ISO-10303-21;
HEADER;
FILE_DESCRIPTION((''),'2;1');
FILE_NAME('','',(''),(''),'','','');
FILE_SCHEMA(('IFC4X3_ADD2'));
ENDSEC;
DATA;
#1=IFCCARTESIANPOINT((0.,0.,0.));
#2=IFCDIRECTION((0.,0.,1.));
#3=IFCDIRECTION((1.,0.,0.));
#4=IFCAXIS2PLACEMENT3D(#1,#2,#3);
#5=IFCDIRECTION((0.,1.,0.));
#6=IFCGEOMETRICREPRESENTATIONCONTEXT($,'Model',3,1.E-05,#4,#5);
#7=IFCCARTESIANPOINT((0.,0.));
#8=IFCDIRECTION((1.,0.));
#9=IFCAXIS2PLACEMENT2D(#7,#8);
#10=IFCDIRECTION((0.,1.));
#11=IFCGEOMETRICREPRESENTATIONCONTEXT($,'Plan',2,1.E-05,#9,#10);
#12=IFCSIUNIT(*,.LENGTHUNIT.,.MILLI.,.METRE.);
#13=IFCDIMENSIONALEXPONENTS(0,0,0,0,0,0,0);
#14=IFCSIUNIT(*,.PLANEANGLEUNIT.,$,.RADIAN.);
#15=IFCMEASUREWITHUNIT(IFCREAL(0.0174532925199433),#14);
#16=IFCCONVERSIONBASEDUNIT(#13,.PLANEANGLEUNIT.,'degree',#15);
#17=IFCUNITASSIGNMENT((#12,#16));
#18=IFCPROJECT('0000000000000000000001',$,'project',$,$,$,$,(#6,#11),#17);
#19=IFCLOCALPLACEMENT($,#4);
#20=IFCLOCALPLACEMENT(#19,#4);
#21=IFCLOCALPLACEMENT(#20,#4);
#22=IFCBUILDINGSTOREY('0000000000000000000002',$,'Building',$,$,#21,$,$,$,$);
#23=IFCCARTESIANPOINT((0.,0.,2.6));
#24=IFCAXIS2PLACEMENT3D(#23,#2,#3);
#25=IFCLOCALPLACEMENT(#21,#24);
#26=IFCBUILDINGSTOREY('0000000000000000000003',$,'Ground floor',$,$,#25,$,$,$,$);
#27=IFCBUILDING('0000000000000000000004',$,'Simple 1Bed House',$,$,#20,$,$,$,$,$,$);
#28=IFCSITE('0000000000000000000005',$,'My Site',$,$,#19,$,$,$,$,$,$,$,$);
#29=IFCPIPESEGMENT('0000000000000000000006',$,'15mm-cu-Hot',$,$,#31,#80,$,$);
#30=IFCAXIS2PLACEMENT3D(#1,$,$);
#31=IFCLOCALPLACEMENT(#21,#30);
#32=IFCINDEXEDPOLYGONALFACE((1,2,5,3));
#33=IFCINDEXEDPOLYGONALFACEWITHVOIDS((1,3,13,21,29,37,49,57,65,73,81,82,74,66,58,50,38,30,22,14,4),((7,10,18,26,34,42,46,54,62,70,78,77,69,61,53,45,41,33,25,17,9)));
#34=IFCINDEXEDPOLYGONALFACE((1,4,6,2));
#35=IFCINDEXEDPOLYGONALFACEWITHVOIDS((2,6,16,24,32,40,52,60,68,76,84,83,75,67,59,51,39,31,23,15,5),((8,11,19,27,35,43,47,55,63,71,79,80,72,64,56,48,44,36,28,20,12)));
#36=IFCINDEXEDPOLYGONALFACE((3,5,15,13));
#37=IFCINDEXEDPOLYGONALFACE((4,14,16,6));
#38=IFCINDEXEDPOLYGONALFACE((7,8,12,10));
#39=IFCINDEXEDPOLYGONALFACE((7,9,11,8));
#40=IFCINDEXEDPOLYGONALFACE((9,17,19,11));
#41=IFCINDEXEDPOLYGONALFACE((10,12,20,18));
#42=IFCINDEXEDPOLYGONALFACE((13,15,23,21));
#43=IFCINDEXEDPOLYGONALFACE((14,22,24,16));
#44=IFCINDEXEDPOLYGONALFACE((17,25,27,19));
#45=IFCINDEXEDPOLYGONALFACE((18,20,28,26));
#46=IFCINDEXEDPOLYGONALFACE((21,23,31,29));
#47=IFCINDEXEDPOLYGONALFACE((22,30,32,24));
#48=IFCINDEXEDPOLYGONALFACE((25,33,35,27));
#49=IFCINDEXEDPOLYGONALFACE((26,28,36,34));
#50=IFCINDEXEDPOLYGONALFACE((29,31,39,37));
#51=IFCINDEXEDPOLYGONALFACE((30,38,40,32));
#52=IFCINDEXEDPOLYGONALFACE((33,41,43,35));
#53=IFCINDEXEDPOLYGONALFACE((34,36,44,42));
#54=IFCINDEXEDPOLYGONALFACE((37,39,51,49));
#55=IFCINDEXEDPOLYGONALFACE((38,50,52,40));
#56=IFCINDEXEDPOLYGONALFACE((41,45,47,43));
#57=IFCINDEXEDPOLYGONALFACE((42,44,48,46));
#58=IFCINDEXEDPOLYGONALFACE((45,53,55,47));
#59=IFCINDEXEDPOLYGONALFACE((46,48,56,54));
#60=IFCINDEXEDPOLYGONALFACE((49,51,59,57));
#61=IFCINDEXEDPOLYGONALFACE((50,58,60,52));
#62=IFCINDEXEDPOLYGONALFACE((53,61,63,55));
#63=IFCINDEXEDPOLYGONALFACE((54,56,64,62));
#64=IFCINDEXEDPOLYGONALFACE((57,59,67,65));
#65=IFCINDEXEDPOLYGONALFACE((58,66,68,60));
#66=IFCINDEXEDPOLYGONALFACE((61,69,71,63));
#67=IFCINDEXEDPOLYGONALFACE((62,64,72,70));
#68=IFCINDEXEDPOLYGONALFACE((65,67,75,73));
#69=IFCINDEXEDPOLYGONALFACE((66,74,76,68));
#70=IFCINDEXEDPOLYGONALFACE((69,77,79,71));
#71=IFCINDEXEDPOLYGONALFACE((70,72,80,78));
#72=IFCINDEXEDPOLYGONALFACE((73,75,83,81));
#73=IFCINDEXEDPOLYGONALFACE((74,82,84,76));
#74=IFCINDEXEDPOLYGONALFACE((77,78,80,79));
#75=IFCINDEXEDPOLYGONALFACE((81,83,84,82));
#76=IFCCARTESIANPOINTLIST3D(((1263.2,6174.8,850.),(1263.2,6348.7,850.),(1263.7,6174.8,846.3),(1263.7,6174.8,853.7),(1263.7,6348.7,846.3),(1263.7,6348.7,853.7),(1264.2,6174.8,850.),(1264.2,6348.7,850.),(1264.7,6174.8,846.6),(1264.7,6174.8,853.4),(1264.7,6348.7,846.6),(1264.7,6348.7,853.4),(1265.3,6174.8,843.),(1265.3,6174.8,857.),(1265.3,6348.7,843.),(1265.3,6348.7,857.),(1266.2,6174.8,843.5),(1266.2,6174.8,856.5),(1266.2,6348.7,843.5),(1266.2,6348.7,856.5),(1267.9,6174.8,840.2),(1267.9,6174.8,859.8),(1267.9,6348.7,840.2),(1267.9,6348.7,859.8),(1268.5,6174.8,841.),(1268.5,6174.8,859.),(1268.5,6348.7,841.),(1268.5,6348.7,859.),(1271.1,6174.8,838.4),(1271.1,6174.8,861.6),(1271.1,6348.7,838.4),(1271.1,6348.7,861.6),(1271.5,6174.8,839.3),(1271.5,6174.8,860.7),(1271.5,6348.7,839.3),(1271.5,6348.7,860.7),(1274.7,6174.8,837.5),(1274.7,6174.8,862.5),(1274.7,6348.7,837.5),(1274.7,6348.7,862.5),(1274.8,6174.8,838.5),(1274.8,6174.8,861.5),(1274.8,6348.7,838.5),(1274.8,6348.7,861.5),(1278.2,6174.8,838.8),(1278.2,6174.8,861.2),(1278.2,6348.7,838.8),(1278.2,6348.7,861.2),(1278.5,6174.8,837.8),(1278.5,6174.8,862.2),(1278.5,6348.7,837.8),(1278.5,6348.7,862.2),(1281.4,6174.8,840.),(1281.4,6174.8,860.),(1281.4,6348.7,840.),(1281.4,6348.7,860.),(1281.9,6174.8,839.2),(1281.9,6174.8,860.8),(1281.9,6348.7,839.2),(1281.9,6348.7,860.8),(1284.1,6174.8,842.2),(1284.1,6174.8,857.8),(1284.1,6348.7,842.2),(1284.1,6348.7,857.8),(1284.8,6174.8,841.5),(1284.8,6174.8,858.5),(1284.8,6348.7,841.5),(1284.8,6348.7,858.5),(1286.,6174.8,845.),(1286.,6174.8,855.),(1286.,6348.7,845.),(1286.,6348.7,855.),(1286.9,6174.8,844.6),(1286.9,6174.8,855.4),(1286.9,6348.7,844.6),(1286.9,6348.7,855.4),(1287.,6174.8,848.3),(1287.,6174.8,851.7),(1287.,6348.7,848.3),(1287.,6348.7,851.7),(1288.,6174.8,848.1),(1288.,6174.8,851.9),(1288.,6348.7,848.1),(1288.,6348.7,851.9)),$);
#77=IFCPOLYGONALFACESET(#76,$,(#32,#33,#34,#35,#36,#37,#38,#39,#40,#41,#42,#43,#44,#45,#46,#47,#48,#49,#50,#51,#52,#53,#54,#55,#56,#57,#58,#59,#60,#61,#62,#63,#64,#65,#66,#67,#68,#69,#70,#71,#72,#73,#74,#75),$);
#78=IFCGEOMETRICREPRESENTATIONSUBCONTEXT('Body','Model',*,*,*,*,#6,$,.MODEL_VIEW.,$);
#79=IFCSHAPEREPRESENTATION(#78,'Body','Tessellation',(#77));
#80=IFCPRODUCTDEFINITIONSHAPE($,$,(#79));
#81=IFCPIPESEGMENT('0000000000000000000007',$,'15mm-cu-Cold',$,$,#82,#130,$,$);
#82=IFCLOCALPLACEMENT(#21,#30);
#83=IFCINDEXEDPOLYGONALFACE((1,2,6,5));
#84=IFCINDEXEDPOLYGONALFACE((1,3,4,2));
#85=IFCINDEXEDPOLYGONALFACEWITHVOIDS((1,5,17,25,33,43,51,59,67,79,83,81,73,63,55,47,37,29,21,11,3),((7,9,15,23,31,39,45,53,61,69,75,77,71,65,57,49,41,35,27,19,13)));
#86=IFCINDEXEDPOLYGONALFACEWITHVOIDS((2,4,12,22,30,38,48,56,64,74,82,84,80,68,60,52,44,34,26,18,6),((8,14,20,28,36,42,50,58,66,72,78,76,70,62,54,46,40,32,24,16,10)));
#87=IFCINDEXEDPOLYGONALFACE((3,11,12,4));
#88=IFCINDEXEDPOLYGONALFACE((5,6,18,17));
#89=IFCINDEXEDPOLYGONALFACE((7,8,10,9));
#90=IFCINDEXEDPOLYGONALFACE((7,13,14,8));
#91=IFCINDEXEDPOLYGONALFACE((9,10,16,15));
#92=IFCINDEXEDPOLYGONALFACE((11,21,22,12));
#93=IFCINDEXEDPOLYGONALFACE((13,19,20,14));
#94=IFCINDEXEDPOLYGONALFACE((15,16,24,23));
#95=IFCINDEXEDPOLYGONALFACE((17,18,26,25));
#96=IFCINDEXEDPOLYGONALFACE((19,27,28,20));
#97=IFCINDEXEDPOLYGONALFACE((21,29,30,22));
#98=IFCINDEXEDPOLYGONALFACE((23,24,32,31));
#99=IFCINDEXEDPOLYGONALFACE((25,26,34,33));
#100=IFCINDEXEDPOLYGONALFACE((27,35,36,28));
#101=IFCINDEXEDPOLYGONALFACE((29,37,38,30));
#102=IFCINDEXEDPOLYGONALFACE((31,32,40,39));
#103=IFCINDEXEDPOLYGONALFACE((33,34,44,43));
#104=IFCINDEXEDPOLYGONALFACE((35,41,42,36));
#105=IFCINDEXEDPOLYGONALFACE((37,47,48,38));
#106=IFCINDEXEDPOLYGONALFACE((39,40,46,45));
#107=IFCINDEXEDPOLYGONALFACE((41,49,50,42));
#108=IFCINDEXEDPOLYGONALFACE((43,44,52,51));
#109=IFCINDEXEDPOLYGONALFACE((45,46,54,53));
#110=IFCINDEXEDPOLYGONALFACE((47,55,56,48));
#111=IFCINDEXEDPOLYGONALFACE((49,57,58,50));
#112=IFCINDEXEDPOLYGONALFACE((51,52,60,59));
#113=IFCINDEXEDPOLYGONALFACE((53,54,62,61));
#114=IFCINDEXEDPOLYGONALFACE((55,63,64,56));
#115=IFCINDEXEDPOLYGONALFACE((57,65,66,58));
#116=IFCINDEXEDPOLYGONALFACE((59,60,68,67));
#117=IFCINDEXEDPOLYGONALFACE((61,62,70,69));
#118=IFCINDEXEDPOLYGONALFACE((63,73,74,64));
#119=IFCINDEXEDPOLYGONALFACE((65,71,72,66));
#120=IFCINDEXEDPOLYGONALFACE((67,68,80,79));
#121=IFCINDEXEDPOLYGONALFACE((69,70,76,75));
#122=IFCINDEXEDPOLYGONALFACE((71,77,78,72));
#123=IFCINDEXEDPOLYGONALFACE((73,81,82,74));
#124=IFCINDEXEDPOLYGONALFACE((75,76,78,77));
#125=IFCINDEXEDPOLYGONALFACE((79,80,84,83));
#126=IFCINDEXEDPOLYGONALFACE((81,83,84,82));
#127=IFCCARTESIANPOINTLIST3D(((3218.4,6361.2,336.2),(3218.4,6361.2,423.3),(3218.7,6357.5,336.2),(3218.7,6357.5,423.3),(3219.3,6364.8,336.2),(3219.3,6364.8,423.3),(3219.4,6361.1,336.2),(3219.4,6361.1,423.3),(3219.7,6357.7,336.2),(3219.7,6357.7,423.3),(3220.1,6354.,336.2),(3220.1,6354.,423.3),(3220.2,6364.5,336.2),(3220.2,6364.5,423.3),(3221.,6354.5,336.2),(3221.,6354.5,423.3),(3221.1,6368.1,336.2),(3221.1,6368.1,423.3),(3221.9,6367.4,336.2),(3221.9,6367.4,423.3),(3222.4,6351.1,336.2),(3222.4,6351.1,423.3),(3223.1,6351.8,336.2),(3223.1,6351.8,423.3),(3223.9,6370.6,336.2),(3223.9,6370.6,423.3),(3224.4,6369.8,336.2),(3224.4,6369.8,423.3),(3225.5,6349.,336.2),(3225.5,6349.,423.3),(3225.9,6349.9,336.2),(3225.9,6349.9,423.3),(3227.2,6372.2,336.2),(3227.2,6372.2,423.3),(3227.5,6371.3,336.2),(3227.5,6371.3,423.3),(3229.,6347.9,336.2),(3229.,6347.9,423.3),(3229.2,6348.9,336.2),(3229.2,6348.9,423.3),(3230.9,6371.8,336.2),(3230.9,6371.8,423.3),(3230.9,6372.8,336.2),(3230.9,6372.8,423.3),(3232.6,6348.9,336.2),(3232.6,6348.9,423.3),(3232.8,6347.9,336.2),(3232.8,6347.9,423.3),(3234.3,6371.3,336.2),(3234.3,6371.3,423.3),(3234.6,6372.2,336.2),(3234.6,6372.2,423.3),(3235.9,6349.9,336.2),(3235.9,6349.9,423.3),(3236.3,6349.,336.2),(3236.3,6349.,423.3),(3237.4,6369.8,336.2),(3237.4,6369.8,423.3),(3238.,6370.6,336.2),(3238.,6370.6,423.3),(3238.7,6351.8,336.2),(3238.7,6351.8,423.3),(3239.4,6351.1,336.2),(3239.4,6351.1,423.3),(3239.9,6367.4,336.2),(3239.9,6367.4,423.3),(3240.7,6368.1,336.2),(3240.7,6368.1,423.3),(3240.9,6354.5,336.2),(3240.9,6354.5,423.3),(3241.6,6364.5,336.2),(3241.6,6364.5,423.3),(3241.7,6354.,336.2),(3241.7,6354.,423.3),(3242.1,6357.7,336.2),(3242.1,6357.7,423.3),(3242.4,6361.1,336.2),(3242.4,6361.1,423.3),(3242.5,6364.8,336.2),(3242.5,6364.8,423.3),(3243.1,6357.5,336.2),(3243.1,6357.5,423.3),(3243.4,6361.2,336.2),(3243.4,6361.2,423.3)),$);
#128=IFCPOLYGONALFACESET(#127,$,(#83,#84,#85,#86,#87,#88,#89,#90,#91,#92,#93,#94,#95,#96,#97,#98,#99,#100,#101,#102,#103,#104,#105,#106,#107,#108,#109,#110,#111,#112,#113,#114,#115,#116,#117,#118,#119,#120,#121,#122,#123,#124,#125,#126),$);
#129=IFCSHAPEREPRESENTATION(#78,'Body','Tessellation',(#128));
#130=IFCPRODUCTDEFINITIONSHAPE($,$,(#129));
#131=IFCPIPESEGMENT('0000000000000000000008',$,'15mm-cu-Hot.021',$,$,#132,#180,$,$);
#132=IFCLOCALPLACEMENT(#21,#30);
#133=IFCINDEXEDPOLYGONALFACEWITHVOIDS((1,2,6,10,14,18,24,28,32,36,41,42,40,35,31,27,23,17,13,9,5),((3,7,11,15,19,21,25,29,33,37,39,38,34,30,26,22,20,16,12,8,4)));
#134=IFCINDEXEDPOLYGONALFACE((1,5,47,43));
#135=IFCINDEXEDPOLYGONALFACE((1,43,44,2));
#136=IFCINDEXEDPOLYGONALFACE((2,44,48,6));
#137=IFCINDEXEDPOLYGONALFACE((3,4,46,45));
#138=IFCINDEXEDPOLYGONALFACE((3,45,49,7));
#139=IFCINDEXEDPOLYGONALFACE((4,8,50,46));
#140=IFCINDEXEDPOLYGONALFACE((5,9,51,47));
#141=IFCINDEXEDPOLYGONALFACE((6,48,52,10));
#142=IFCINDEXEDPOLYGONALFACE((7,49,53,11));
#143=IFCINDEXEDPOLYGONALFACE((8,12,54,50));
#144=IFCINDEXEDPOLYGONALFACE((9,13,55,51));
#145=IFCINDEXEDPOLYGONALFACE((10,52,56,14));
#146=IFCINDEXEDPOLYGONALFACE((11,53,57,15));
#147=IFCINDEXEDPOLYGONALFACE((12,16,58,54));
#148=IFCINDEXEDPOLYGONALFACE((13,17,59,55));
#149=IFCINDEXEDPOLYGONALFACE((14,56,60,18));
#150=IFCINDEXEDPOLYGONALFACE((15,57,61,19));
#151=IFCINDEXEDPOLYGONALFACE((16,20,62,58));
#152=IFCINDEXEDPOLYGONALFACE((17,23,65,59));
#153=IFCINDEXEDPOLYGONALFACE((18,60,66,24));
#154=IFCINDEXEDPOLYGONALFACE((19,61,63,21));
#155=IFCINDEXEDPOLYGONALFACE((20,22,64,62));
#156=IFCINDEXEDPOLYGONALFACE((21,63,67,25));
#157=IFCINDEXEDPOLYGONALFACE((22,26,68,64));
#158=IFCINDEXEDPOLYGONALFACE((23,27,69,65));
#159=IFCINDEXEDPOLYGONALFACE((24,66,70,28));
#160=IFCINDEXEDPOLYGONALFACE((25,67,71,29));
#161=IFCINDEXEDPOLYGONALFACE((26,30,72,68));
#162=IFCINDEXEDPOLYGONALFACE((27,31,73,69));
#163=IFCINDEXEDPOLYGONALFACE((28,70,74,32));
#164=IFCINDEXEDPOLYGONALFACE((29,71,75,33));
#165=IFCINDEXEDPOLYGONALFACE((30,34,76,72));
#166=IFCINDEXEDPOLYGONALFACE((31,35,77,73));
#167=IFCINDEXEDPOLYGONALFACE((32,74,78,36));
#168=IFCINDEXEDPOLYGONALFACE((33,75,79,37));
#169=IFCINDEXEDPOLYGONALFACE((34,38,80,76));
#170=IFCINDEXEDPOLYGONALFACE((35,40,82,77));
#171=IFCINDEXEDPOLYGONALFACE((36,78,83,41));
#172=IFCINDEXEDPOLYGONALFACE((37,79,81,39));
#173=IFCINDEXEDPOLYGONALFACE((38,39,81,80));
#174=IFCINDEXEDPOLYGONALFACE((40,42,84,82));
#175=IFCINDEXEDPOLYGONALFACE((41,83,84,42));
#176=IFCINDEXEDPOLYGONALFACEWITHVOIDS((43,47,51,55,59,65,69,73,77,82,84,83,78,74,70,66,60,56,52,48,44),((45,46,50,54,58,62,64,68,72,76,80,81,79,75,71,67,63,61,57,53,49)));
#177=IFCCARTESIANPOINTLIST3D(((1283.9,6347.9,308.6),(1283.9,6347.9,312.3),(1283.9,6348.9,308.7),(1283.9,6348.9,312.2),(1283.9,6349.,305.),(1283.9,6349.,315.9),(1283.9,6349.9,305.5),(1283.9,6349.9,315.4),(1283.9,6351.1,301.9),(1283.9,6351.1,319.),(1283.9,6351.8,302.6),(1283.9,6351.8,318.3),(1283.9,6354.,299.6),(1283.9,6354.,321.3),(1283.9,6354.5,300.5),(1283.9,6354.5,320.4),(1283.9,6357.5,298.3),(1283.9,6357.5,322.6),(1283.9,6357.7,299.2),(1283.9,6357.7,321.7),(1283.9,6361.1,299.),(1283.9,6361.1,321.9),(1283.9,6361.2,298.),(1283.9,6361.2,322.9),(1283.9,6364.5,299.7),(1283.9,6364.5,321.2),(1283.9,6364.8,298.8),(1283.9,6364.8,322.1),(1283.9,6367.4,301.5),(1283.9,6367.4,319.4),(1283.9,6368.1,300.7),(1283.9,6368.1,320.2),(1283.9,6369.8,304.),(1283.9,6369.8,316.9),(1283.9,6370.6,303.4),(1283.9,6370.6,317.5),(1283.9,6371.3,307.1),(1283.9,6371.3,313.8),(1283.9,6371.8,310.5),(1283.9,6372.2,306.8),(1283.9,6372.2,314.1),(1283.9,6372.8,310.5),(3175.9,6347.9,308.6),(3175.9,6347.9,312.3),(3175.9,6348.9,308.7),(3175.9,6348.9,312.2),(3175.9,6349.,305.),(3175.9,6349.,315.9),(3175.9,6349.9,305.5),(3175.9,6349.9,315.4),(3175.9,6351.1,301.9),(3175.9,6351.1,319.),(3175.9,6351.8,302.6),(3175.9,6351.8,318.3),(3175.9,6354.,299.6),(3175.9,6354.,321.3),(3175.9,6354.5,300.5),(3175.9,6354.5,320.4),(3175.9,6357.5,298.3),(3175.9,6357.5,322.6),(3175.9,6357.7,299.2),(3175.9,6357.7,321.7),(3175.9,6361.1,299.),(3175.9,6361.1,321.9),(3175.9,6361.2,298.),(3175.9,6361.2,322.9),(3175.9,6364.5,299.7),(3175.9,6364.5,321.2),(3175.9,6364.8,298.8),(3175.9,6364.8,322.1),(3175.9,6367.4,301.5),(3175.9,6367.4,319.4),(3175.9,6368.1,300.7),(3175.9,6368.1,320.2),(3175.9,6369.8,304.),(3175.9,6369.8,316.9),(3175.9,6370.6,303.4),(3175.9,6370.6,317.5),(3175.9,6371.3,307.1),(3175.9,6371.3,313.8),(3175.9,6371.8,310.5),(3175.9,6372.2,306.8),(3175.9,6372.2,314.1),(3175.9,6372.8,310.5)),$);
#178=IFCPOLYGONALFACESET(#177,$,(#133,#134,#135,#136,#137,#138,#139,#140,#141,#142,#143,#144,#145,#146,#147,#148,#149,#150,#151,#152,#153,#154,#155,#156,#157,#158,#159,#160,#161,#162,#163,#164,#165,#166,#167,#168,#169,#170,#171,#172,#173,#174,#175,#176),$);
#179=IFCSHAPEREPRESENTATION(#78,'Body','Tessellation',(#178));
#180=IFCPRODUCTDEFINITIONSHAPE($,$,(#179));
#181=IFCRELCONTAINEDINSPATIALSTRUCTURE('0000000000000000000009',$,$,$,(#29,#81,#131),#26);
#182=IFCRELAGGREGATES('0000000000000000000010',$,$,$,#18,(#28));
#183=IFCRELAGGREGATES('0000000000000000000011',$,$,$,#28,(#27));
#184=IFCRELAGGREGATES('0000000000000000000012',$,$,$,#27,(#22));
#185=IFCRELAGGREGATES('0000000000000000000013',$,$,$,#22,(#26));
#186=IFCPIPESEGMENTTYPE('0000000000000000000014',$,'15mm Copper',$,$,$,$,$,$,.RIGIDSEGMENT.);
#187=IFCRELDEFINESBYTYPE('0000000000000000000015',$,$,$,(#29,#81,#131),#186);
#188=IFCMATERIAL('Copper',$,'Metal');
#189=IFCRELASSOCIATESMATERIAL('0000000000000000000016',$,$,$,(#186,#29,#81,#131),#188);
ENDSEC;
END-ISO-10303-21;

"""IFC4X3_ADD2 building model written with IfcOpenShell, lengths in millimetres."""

from ifc_helpers import new_model, entity, si_unit, converted_unit, direction, frame, origin_with_axes, origin_2d_with_axis, place, context, subcontext, project, spatial, hollow_circle, extrude, material, material_profile, profile_set, profile_usage, type_object, element, save


model = new_model("IFC4X3_ADD2")

# Units and contexts
model_context = context("Model", 3, precision=1e-05, world=origin_with_axes(), true_north=direction((0.0, 1.0, 0.0)))
plan_context = context("Plan", 2, precision=1e-05, world=origin_2d_with_axis(), true_north=direction((0.0, 1.0)))
body_context_1 = subcontext(model_context, "Body", "Model", "MODEL_VIEW")
ifc_project = project(units=[si_unit("LENGTHUNIT", "METRE", prefix="MILLI"), converted_unit("PLANEANGLEUNIT", "degree", entity("IfcReal", 0.0174532925199433), si_unit("PLANEANGLEUNIT", "RADIAN"), dimensions=[0, 0, 0, 0, 0, 0, 0])], contexts=[model_context, plan_context])

# Site, building, storeys
site_placement = place(None, origin_with_axes())
site = spatial("IfcSite", under=ifc_project, at=site_placement, Name="My Site")
building_placement = place(site_placement, origin_with_axes())
building = spatial("IfcBuilding", under=site, at=building_placement, Name="Simple 1Bed House")
storey_1_placement = place(building_placement, origin_with_axes())
storey_1 = spatial("IfcBuildingStorey", under=building, at=storey_1_placement, Name="Building")
storey_2_placement = place(storey_1_placement, frame((0.0, 0.0, 2.6), z_axis=(0.0, 0.0, 1.0), x_axis=(1.0, 0.0, 0.0)))
storey_2 = spatial("IfcBuildingStorey", under=storey_1, at=storey_2_placement, Name="Ground floor")

# Pipe segments
ifc_material_1 = material(Name="Copper", Category="Metal")
ifc_material_profile_1 = material_profile(ifc_material_1, hollow_circle(Radius=12.5, WallThickness=1.0))
ifc_profile_set_1 = profile_set([ifc_material_profile_1])
pipe_segment_type_1 = type_object("IfcPipeSegmentType", Name="15mm Copper", PredefinedType="RIGIDSEGMENT", material=ifc_profile_set_1)
ifc_profile_usage_1 = profile_usage(ifc_profile_set_1, cardinal=5)
pipe_segment_1_placement = place(storey_2_placement, frame((1275.7, 6348.7, 847.4), z_axis=(0.0, -1.0, 0.0), x_axis=(-1.0, 0.0, 0.0)))
element("IfcPipeSegment", 1, at=pipe_segment_1_placement, inside=storey_2, type_object=pipe_segment_type_1, material=ifc_profile_usage_1, Name="15mm-cu-Hot", context=body_context_1, shape_type="SweptSolid", body=[
    extrude(hollow_circle(Radius=12.5, WallThickness=1.0), origin_with_axes(), (0.0, 0.0, 1.0), 173.9),
])
ifc_profile_usage_2 = profile_usage(ifc_profile_set_1, cardinal=5)
pipe_segment_2_placement = place(storey_2_placement, frame((3230.9, 6360.3, 420.7), z_axis=(0.0, 0.0, -1.0), x_axis=(0.0, 1.0, 0.0)))
element("IfcPipeSegment", 2, at=pipe_segment_2_placement, inside=storey_2, type_object=pipe_segment_type_1, material=ifc_profile_usage_2, Name="15mm-cu-Cold", context=body_context_1, shape_type="SweptSolid", body=[
    extrude(hollow_circle(Radius=12.5, WallThickness=1.0), origin_with_axes(), (0.0, 0.0, 1.0), 87.1),
])
ifc_profile_usage_3 = profile_usage(ifc_profile_set_1, cardinal=5)
pipe_segment_3_placement = place(storey_2_placement, frame((1283.9, 6360.3, 307.9), z_axis=(1.0, 0.0, 0.0), x_axis=(0.0, 1.0, 0.0)))
element("IfcPipeSegment", 3, at=pipe_segment_3_placement, inside=storey_2, type_object=pipe_segment_type_1, material=ifc_profile_usage_3, Name="15mm-cu-Hot.021", context=body_context_1, shape_type="SweptSolid", body=[
    extrude(hollow_circle(Radius=12.5, WallThickness=1.0), origin_with_axes(), (0.0, 0.0, 1.0), 1892.0),
])

save(model, "model.ifc")
